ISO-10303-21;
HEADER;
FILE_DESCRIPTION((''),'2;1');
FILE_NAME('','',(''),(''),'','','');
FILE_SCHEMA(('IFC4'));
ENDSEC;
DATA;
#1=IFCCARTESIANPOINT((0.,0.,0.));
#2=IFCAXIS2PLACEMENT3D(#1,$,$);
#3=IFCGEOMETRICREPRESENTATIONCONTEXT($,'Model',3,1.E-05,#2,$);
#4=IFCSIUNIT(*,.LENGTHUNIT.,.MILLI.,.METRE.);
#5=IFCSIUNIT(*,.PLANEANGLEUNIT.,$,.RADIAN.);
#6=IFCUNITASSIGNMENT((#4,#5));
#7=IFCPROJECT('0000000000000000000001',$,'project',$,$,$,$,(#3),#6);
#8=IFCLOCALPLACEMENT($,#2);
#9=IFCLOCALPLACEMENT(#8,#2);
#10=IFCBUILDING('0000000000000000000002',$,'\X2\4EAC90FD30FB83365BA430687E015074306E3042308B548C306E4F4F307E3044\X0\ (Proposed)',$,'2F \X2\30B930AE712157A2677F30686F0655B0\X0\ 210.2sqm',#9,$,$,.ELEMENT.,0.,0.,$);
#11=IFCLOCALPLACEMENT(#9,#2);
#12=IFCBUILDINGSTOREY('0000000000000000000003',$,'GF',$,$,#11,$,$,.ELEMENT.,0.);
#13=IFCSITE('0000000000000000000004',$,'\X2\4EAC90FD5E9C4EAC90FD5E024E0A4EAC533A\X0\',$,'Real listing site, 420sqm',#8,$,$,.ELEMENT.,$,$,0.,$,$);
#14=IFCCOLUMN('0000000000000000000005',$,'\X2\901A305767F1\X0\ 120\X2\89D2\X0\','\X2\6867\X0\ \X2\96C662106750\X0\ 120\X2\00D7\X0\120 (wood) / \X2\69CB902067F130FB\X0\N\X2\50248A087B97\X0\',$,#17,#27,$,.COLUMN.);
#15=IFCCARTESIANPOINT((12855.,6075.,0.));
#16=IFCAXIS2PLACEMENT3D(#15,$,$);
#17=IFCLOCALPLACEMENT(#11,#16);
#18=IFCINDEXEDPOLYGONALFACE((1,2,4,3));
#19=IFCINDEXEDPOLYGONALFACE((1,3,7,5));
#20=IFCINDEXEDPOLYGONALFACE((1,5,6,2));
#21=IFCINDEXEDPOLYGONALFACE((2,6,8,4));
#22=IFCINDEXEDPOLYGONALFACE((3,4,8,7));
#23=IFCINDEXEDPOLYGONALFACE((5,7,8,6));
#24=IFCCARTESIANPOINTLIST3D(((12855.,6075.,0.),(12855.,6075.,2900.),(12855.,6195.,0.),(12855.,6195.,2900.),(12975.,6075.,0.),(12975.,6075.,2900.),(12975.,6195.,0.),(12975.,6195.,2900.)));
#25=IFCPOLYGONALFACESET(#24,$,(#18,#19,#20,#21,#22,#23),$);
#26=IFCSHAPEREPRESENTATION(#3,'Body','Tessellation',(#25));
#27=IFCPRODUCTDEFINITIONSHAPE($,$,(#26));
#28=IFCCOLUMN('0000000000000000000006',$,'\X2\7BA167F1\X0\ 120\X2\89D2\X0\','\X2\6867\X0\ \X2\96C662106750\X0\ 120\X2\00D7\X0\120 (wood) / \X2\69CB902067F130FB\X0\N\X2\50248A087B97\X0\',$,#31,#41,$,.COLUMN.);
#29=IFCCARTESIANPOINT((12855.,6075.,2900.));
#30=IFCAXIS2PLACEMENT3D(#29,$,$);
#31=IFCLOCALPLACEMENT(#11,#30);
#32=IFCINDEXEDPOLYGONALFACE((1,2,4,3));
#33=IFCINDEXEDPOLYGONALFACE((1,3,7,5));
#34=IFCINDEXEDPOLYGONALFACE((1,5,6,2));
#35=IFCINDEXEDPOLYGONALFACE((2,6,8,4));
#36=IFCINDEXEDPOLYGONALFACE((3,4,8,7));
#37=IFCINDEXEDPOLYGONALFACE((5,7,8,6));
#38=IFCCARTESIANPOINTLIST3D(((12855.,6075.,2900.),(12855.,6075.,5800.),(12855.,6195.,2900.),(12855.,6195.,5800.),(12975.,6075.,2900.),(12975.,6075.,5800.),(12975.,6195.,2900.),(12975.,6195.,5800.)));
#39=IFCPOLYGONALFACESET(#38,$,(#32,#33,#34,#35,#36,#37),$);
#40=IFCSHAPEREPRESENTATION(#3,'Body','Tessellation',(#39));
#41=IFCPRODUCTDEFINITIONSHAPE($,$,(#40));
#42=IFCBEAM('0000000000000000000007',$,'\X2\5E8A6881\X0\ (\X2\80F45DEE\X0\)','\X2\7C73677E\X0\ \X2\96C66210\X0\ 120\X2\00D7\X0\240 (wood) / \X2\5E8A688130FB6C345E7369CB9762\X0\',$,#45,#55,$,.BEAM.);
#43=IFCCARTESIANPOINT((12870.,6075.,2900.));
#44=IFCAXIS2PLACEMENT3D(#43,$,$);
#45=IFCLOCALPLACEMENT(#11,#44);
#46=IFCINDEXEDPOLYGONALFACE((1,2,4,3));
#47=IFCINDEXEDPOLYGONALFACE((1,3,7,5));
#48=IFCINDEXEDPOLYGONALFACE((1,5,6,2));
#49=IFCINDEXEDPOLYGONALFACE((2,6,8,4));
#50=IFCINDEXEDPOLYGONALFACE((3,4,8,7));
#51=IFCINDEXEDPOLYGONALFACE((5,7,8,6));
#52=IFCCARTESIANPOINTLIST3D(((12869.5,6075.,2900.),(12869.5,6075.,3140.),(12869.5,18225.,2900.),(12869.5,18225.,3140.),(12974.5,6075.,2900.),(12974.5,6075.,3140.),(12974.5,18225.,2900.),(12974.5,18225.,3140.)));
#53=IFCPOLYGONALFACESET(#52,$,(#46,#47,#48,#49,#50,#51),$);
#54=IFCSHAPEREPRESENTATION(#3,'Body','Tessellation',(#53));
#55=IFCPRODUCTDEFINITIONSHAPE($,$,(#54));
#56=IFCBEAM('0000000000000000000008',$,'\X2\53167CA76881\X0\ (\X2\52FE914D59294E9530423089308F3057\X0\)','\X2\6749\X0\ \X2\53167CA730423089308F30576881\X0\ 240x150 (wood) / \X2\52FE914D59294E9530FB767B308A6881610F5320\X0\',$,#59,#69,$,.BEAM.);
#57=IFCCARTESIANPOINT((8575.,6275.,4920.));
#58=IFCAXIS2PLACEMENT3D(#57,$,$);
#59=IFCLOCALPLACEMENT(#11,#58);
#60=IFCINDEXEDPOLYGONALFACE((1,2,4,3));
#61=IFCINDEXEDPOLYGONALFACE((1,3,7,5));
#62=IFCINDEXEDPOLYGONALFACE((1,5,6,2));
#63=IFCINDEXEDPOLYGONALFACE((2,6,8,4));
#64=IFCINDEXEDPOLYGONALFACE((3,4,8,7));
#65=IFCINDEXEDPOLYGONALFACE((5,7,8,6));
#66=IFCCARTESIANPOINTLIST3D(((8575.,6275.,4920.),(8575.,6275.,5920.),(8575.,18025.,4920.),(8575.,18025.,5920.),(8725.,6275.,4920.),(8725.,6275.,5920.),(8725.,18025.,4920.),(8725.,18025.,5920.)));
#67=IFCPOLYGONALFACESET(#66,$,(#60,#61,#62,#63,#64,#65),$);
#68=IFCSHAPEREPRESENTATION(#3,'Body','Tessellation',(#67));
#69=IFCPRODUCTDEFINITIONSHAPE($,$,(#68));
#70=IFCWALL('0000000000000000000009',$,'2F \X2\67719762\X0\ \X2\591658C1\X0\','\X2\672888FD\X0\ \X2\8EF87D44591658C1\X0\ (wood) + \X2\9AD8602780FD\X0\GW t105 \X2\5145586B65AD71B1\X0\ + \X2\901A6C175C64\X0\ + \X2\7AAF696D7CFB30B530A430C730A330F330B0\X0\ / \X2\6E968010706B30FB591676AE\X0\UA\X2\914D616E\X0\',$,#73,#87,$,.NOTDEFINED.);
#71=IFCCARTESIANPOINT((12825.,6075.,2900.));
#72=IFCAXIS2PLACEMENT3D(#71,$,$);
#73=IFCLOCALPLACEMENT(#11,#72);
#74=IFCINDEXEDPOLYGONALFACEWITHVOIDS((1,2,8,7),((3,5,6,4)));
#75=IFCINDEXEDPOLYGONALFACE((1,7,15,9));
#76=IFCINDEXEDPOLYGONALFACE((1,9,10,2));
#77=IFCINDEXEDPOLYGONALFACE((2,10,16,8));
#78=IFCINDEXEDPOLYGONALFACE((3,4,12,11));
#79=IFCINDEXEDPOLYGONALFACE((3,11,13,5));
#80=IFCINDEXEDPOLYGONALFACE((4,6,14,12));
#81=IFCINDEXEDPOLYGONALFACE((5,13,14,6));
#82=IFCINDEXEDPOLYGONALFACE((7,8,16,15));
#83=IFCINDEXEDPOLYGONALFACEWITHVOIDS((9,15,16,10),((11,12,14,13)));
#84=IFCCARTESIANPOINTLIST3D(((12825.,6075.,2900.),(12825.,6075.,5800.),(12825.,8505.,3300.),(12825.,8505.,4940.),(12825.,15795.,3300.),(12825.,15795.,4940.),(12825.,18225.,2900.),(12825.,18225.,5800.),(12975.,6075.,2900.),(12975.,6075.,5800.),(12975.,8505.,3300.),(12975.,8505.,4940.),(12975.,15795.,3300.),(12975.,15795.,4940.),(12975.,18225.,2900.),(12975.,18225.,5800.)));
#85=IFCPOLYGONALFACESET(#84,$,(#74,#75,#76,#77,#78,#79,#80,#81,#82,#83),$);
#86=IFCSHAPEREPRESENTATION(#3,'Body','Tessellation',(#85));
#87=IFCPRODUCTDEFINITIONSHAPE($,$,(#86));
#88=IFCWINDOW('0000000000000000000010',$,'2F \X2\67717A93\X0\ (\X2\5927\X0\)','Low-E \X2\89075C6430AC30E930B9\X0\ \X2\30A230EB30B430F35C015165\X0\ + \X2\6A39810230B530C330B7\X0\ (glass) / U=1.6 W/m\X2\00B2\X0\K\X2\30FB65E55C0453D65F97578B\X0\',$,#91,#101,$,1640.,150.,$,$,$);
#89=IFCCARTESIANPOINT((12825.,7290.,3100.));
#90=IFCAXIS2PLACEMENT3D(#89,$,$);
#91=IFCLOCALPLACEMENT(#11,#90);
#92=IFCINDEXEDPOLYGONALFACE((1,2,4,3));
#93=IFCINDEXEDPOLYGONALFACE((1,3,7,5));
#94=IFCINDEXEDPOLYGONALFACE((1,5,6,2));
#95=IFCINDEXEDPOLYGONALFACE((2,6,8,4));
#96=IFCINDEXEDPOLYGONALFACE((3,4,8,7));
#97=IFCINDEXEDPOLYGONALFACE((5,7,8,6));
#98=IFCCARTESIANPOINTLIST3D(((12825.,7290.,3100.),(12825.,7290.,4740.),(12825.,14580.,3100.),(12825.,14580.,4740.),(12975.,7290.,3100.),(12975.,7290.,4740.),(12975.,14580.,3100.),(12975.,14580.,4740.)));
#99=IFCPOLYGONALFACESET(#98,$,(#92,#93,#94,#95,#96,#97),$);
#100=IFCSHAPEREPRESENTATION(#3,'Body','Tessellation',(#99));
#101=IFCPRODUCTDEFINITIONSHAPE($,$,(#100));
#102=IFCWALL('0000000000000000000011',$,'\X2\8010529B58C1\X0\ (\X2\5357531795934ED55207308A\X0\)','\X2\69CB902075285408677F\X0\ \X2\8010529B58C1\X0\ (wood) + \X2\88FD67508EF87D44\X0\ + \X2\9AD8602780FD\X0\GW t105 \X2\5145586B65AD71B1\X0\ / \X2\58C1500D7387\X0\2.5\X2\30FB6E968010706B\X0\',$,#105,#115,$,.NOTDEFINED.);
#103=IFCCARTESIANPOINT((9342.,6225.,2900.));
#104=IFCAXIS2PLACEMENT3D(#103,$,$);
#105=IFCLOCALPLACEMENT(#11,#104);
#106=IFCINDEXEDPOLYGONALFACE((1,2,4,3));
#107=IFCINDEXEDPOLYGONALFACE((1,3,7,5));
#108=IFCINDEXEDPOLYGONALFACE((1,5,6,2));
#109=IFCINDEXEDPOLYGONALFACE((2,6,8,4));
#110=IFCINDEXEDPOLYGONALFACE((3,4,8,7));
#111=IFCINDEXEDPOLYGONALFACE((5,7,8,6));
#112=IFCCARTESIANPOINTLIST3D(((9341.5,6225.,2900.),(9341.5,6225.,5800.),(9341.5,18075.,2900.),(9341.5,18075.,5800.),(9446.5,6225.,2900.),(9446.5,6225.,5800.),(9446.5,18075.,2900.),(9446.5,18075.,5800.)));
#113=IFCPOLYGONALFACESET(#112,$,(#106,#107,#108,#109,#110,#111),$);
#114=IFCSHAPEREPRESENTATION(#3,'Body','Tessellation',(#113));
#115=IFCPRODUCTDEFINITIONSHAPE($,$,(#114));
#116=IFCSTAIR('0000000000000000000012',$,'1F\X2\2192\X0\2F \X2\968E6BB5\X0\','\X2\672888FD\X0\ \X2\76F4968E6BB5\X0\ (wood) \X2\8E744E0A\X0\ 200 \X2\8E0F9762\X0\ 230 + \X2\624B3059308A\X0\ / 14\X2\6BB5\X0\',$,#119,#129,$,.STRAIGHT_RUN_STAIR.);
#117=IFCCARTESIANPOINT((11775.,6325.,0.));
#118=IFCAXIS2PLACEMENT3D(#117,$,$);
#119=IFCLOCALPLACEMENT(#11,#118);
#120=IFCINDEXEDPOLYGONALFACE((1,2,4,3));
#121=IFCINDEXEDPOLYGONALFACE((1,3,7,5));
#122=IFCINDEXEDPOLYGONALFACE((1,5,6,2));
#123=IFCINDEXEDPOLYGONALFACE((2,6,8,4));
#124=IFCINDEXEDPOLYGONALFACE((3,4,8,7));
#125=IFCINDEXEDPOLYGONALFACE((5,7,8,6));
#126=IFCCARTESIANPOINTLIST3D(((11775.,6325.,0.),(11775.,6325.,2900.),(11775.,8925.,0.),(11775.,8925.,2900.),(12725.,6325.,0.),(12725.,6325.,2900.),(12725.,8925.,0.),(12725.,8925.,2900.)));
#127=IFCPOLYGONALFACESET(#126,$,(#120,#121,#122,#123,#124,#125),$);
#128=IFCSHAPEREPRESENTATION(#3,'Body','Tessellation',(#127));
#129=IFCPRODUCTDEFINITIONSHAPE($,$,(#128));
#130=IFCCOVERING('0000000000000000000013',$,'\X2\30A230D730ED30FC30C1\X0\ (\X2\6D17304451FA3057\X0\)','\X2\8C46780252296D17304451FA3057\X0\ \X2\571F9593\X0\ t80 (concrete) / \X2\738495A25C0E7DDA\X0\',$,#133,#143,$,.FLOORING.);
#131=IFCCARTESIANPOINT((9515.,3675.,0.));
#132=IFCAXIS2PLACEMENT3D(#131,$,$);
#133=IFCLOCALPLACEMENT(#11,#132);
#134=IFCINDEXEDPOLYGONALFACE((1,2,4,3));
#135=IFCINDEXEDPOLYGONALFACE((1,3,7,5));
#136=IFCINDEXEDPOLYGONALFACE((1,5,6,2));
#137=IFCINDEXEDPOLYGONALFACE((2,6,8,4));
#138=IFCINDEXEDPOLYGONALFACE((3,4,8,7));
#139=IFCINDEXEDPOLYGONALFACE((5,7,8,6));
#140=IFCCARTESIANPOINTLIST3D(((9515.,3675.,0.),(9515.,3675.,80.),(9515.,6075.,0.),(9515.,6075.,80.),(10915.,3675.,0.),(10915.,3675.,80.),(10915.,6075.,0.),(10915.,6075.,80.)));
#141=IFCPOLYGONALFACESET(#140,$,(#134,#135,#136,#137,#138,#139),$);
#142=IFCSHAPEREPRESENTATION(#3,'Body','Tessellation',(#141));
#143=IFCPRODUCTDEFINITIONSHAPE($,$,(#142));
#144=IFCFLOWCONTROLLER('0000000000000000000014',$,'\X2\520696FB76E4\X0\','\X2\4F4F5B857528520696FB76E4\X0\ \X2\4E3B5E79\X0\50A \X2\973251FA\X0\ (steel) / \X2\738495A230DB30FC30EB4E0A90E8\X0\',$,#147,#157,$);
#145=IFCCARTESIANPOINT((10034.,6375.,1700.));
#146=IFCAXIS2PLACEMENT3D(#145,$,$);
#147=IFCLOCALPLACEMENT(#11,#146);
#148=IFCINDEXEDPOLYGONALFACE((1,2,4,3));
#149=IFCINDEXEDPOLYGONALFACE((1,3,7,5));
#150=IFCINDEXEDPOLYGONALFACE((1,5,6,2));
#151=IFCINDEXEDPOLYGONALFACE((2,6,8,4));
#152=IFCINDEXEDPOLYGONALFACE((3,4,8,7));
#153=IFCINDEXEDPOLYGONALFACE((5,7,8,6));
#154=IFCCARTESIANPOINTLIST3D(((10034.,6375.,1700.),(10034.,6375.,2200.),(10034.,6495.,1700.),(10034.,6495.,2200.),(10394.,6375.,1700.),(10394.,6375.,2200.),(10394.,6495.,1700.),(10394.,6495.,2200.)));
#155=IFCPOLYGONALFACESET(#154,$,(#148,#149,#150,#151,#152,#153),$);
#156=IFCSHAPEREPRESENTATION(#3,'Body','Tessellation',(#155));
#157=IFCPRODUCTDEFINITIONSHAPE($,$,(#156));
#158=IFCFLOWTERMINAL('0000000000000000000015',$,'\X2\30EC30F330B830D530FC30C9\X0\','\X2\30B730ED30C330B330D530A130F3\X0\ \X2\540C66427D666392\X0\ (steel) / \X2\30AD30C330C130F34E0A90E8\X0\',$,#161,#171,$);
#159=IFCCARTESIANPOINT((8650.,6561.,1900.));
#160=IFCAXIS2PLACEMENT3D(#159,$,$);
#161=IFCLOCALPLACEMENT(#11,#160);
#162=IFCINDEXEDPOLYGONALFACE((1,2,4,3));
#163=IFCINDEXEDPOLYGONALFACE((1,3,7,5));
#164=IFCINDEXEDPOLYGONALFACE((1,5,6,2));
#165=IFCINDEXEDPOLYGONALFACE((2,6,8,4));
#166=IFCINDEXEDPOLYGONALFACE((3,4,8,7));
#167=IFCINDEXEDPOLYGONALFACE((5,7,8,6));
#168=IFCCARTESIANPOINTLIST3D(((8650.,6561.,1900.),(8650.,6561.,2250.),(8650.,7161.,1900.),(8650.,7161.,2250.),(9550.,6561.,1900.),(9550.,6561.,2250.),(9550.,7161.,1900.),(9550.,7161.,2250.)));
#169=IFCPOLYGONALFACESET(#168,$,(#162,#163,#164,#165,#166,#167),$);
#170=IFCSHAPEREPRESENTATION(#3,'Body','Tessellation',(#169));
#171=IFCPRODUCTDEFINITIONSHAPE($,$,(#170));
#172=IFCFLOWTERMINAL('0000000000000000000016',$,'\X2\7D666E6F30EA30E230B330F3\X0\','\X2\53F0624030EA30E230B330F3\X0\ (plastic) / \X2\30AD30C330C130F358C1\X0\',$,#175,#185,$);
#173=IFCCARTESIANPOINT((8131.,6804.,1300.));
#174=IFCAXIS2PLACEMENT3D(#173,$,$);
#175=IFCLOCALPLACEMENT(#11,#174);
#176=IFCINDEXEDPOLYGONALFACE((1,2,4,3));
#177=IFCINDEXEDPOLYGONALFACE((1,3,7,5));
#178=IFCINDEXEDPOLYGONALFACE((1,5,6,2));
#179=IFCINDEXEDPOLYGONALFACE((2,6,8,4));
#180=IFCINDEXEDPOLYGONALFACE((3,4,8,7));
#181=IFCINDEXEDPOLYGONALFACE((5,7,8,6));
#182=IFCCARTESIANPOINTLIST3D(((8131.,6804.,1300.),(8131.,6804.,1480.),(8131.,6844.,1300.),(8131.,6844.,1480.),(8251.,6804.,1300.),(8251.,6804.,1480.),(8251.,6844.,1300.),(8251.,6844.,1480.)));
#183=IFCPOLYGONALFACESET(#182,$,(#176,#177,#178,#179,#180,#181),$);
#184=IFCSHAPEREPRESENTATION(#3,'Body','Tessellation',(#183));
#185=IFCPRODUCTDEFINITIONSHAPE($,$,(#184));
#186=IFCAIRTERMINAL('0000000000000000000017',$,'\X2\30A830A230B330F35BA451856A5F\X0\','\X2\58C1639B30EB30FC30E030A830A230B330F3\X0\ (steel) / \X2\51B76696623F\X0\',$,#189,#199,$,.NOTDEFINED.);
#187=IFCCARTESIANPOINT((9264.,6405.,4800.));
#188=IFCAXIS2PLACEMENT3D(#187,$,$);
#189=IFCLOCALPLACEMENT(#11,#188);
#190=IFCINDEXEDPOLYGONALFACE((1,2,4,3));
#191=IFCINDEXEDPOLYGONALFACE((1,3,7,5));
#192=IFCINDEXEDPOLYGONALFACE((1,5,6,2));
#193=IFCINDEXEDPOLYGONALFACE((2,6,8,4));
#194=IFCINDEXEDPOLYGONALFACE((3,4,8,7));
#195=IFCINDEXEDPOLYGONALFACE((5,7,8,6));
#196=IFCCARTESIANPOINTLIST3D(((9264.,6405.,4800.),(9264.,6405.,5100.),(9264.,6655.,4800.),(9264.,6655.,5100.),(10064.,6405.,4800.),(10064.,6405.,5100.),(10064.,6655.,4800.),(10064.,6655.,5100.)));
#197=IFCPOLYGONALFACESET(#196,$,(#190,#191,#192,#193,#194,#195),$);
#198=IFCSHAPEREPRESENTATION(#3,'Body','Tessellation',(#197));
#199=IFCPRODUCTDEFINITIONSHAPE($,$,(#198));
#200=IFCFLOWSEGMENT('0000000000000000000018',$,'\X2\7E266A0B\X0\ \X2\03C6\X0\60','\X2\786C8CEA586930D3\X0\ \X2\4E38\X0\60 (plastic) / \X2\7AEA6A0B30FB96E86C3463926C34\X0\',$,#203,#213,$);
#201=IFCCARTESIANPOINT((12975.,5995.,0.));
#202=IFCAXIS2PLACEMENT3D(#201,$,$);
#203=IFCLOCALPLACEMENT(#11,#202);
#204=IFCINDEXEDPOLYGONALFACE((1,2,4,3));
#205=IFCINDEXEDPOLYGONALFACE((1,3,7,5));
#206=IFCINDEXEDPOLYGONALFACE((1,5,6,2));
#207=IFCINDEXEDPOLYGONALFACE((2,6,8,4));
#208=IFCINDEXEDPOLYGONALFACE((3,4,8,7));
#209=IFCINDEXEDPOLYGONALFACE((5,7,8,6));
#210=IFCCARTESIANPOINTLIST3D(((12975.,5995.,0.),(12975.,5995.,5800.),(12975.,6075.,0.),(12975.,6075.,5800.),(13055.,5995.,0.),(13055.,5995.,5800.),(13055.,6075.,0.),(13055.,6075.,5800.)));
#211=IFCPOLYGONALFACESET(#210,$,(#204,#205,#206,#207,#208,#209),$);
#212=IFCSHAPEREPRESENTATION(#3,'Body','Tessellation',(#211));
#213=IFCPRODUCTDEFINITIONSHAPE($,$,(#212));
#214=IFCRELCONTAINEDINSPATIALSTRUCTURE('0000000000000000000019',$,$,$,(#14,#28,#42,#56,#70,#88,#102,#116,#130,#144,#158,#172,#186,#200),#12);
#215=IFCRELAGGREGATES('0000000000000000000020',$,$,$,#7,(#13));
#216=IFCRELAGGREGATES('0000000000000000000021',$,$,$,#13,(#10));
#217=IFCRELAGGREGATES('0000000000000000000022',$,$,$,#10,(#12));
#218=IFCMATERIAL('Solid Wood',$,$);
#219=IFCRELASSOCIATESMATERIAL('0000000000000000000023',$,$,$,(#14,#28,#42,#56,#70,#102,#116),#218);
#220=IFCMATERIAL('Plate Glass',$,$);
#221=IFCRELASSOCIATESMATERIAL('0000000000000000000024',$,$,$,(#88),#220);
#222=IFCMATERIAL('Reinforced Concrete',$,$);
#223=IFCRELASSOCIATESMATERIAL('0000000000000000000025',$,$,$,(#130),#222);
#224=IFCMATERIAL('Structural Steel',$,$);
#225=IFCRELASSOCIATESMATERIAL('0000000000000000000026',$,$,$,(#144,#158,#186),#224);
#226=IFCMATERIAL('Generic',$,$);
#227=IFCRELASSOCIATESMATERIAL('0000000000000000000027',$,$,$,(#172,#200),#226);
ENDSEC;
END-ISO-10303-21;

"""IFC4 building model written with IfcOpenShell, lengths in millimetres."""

from ifc_helpers import new_model, si_unit, frame, frame_2d, origin, place, context, project, spatial, rectangle, extrude, material, element, fill, save


model = new_model("IFC4")

# Units and contexts
model_context = context("Model", 3, precision=1e-05, world=origin())
ifc_project = project(units=[si_unit("LENGTHUNIT", "METRE", prefix="MILLI"), si_unit("PLANEANGLEUNIT", "RADIAN")], contexts=[model_context])

# Site, building, storey
site_placement = place(None, origin())
site = spatial("IfcSite", under=ifc_project, at=site_placement, Name="京都府京都市上京区", ObjectType="Real listing site, 420sqm", CompositionType="ELEMENT", RefElevation=0.0)
building_placement = place(site_placement, origin())
building = spatial("IfcBuilding", under=site, at=building_placement, Name="京都・茶室と縁側のある和の住まい (Proposed)", ObjectType="2F スギ無垢板と漆喰 210.2sqm", CompositionType="ELEMENT", ElevationOfRefHeight=0.0, ElevationOfTerrain=0.0)
storey_placement = place(building_placement, origin())
storey = spatial("IfcBuildingStorey", under=building, at=storey_placement, Name="GF", CompositionType="ELEMENT", Elevation=0.0)

# Columns
ifc_material_1 = material(Name="Solid Wood")
column_1_placement = place(storey_placement, frame((12855.0, 6075.0, 0.0)))
element("IfcColumn", 1, at=column_1_placement, inside=storey, material=ifc_material_1, Name="通し柱 120角", Description="桧 集成材 120×120 (wood) / 構造柱・N値計算", PredefinedType="COLUMN", context=model_context, shape_type="SweptSolid", body=[
    extrude(rectangle(XDim=120.0, YDim=120.0, at=frame_2d((60.0, 60.0))), frame((12855.0, 6075.0, 0.0)), (0.0, 0.0, 1.0), 2900.0),
])
column_2_placement = place(storey_placement, frame((12855.0, 6075.0, 2900.0)))
element("IfcColumn", 2, at=column_2_placement, inside=storey, material=ifc_material_1, Name="管柱 120角", Description="桧 集成材 120×120 (wood) / 構造柱・N値計算", PredefinedType="COLUMN", context=model_context, shape_type="SweptSolid", body=[
    extrude(rectangle(XDim=120.0, YDim=120.0, at=frame_2d((60.0, 60.0))), frame((12855.0, 6075.0, 2900.0)), (0.0, 0.0, 1.0), 2900.0),
])

# Beams
beam_1_placement = place(storey_placement, frame((12870.0, 6075.0, 2900.0)))
element("IfcBeam", 3, at=beam_1_placement, inside=storey, material=ifc_material_1, Name="床梁 (胴差)", Description="米松 集成 120×240 (wood) / 床梁・水平構面", PredefinedType="BEAM", context=model_context, shape_type="SweptSolid", body=[
    extrude(rectangle(XDim=105.0, YDim=12150.0, at=frame_2d((52.0, 6075.0))), frame((12870.0, 6075.0, 2900.0)), (0.0, 0.0, 1.0), 240.0),
])
beam_2_placement = place(storey_placement, frame((8575.0, 6275.0, 4920.0)))
element("IfcBeam", 4, at=beam_2_placement, inside=storey, material=ifc_material_1, Name="化粧梁 (勾配天井あらわし)", Description="杉 化粧あらわし梁 240x150 (wood) / 勾配天井・登り梁意匠", PredefinedType="BEAM", context=model_context, shape_type="SweptSolid", body=[
    extrude(rectangle(XDim=150.0, YDim=11750.0, at=frame_2d((75.0, 5875.0))), frame((8575.0, 6275.0, 4920.0)), (0.0, 0.0, 1.0), 1000.0),
])

# Shared definitions
ifc_material_2 = material(Name="Plate Glass")

# Wall, opening, window
wall_1_placement = place(storey_placement, frame((12825.0, 6075.0, 2900.0)))
wall_1 = element("IfcWall", 5, at=wall_1_placement, inside=storey, material=ifc_material_1, Name="2F 東面 外壁", Description="木製 軸組外壁 (wood) + 高性能GW t105 充填断熱 + 通気層 + 窯業系サイディング / 準耐火・外皮UA配慮", PredefinedType="NOTDEFINED", context=model_context, shape_type="SweptSolid", body=[
    extrude(rectangle(XDim=150.0, YDim=12150.0, at=frame_2d((75.0, 6075.0))), frame((12825.0, 6075.0, 2900.0)), (0.0, 0.0, 1.0), 2900.0),
])
opening_1_placement = place(storey_placement, frame((12825.0, 7290.0, 3100.0)))
opening_1 = element("IfcOpeningElement", 6, at=opening_1_placement, cuts=wall_1, PredefinedType="NOTDEFINED", context=model_context, shape_type="SweptSolid", body=[
    extrude(rectangle(XDim=150.0, YDim=7290.0, at=frame_2d((75.0, 3645.0))), frame((12825.0, 7290.0, 3100.0)), (0.0, 0.0, 1.0), 1640.0),
])
window_1_placement = place(storey_placement, frame((12825.0, 7290.0, 3100.0)))
window_1 = element("IfcWindow", 7, at=window_1_placement, inside=storey, material=ifc_material_2, Name="2F 東窓 (大)", Description="Low-E 複層ガラス アルゴン封入 + 樹脂サッシ (glass) / U=1.6 W/m²K・日射取得型", OverallHeight=1640.0, OverallWidth=150.0, context=model_context, shape_type="SweptSolid", body=[
    extrude(rectangle(XDim=150.0, YDim=7290.0, at=frame_2d((75.0, 3645.0))), frame((12825.0, 7290.0, 3100.0)), (0.0, 0.0, 1.0), 1640.0),
])
fill(opening_1, window_1)

# Wall
wall_2_placement = place(storey_placement, frame((9342.0, 6225.0, 2900.0)))
element("IfcWall", 8, at=wall_2_placement, inside=storey, material=ifc_material_1, Name="耐力壁 (南北間仕切り)", Description="構造用合板 耐力壁 (wood) + 製材軸組 + 高性能GW t105 充填断熱 / 壁倍率2.5・準耐火", PredefinedType="NOTDEFINED", context=model_context, shape_type="SweptSolid", body=[
    extrude(rectangle(XDim=105.0, YDim=11850.0, at=frame_2d((52.0, 5925.0))), frame((9342.0, 6225.0, 2900.0)), (0.0, 0.0, 1.0), 2900.0),
])

# Stair
stair_placement = place(storey_placement, frame((11775.0, 6325.0, 0.0)))
element("IfcStair", 9, at=stair_placement, inside=storey, material=ifc_material_1, Name="1F→2F 階段", Description="木製 直階段 (wood) 蹴上 200 踏面 230 + 手すり / 14段", PredefinedType="STRAIGHT_RUN_STAIR", context=model_context, shape_type="SweptSolid", body=[
    extrude(rectangle(XDim=950.0, YDim=2600.0, at=frame_2d((475.0, 1300.0))), frame((11775.0, 6325.0, 0.0)), (0.0, 0.0, 1.0), 2900.0),
])

# Covering
ifc_material_3 = material(Name="Reinforced Concrete")
covering_placement = place(storey_placement, frame((9515.0, 3675.0, 0.0)))
element("IfcCovering", 10, at=covering_placement, inside=storey, material=ifc_material_3, Name="アプローチ (洗い出し)", Description="豆砂利洗い出し 土間 t80 (concrete) / 玄関導線", PredefinedType="FLOORING", context=model_context, shape_type="SweptSolid", body=[
    extrude(rectangle(XDim=1400.0, YDim=2400.0, at=frame_2d((700.0, 1200.0))), frame((9515.0, 3675.0, 0.0)), (0.0, 0.0, 1.0), 80.0),
])

# Flow controller
ifc_material_4 = material(Name="Structural Steel")
flow_controller_placement = place(storey_placement, frame((10034.0, 6375.0, 1700.0)))
element("IfcFlowController", 11, at=flow_controller_placement, inside=storey, material=ifc_material_4, Name="分電盤", Description="住宅用分電盤 主幹50A 露出 (steel) / 玄関ホール上部", context=model_context, shape_type="SweptSolid", body=[
    extrude(rectangle(XDim=360.0, YDim=120.0, at=frame_2d((180.0, 60.0))), frame((10034.0, 6375.0, 1700.0)), (0.0, 0.0, 1.0), 500.0),
])

# Flow terminals
flow_terminal_1_placement = place(storey_placement, frame((8650.0, 6561.0, 1900.0)))
element("IfcFlowTerminal", 12, at=flow_terminal_1_placement, inside=storey, material=ifc_material_4, Name="レンジフード", Description="シロッコファン 同時給排 (steel) / キッチン上部", context=model_context, shape_type="SweptSolid", body=[
    extrude(rectangle(XDim=900.0, YDim=600.0, at=frame_2d((450.0, 300.0))), frame((8650.0, 6561.0, 1900.0)), (0.0, 0.0, 1.0), 350.0),
])
ifc_material_5 = material(Name="Generic")
flow_terminal_2_placement = place(storey_placement, frame((8131.0, 6804.0, 1300.0)))
element("IfcFlowTerminal", 13, at=flow_terminal_2_placement, inside=storey, material=ifc_material_5, Name="給湯リモコン", Description="台所リモコン (plastic) / キッチン壁", context=model_context, shape_type="SweptSolid", body=[
    extrude(rectangle(XDim=120.0, YDim=40.0, at=frame_2d((60.0, 20.0))), frame((8131.0, 6804.0, 1300.0)), (0.0, 0.0, 1.0), 180.0),
])

# Air terminal
air_terminal_placement = place(storey_placement, frame((9264.0, 6405.0, 4800.0)))
element("IfcAirTerminal", 14, at=air_terminal_placement, inside=storey, material=ifc_material_4, Name="エアコン室内機", Description="壁掛ルームエアコン (steel) / 冷暖房", PredefinedType="NOTDEFINED", context=model_context, shape_type="SweptSolid", body=[
    extrude(rectangle(XDim=800.0, YDim=250.0, at=frame_2d((400.0, 125.0))), frame((9264.0, 6405.0, 4800.0)), (0.0, 0.0, 1.0), 300.0),
])

# Flow segment
flow_segment_placement = place(storey_placement, frame((12975.0, 5995.0, 0.0)))
element("IfcFlowSegment", 15, at=flow_segment_placement, inside=storey, material=ifc_material_5, Name="縦樋 φ60", Description="硬質塩ビ 丸60 (plastic) / 竪樋・雨水排水", context=model_context, shape_type="SweptSolid", body=[
    extrude(rectangle(XDim=80.0, YDim=80.0, at=frame_2d((40.0, 40.0))), frame((12975.0, 5995.0, 0.0)), (0.0, 0.0, 1.0), 5800.0),
])

save(model, "model.ifc")
